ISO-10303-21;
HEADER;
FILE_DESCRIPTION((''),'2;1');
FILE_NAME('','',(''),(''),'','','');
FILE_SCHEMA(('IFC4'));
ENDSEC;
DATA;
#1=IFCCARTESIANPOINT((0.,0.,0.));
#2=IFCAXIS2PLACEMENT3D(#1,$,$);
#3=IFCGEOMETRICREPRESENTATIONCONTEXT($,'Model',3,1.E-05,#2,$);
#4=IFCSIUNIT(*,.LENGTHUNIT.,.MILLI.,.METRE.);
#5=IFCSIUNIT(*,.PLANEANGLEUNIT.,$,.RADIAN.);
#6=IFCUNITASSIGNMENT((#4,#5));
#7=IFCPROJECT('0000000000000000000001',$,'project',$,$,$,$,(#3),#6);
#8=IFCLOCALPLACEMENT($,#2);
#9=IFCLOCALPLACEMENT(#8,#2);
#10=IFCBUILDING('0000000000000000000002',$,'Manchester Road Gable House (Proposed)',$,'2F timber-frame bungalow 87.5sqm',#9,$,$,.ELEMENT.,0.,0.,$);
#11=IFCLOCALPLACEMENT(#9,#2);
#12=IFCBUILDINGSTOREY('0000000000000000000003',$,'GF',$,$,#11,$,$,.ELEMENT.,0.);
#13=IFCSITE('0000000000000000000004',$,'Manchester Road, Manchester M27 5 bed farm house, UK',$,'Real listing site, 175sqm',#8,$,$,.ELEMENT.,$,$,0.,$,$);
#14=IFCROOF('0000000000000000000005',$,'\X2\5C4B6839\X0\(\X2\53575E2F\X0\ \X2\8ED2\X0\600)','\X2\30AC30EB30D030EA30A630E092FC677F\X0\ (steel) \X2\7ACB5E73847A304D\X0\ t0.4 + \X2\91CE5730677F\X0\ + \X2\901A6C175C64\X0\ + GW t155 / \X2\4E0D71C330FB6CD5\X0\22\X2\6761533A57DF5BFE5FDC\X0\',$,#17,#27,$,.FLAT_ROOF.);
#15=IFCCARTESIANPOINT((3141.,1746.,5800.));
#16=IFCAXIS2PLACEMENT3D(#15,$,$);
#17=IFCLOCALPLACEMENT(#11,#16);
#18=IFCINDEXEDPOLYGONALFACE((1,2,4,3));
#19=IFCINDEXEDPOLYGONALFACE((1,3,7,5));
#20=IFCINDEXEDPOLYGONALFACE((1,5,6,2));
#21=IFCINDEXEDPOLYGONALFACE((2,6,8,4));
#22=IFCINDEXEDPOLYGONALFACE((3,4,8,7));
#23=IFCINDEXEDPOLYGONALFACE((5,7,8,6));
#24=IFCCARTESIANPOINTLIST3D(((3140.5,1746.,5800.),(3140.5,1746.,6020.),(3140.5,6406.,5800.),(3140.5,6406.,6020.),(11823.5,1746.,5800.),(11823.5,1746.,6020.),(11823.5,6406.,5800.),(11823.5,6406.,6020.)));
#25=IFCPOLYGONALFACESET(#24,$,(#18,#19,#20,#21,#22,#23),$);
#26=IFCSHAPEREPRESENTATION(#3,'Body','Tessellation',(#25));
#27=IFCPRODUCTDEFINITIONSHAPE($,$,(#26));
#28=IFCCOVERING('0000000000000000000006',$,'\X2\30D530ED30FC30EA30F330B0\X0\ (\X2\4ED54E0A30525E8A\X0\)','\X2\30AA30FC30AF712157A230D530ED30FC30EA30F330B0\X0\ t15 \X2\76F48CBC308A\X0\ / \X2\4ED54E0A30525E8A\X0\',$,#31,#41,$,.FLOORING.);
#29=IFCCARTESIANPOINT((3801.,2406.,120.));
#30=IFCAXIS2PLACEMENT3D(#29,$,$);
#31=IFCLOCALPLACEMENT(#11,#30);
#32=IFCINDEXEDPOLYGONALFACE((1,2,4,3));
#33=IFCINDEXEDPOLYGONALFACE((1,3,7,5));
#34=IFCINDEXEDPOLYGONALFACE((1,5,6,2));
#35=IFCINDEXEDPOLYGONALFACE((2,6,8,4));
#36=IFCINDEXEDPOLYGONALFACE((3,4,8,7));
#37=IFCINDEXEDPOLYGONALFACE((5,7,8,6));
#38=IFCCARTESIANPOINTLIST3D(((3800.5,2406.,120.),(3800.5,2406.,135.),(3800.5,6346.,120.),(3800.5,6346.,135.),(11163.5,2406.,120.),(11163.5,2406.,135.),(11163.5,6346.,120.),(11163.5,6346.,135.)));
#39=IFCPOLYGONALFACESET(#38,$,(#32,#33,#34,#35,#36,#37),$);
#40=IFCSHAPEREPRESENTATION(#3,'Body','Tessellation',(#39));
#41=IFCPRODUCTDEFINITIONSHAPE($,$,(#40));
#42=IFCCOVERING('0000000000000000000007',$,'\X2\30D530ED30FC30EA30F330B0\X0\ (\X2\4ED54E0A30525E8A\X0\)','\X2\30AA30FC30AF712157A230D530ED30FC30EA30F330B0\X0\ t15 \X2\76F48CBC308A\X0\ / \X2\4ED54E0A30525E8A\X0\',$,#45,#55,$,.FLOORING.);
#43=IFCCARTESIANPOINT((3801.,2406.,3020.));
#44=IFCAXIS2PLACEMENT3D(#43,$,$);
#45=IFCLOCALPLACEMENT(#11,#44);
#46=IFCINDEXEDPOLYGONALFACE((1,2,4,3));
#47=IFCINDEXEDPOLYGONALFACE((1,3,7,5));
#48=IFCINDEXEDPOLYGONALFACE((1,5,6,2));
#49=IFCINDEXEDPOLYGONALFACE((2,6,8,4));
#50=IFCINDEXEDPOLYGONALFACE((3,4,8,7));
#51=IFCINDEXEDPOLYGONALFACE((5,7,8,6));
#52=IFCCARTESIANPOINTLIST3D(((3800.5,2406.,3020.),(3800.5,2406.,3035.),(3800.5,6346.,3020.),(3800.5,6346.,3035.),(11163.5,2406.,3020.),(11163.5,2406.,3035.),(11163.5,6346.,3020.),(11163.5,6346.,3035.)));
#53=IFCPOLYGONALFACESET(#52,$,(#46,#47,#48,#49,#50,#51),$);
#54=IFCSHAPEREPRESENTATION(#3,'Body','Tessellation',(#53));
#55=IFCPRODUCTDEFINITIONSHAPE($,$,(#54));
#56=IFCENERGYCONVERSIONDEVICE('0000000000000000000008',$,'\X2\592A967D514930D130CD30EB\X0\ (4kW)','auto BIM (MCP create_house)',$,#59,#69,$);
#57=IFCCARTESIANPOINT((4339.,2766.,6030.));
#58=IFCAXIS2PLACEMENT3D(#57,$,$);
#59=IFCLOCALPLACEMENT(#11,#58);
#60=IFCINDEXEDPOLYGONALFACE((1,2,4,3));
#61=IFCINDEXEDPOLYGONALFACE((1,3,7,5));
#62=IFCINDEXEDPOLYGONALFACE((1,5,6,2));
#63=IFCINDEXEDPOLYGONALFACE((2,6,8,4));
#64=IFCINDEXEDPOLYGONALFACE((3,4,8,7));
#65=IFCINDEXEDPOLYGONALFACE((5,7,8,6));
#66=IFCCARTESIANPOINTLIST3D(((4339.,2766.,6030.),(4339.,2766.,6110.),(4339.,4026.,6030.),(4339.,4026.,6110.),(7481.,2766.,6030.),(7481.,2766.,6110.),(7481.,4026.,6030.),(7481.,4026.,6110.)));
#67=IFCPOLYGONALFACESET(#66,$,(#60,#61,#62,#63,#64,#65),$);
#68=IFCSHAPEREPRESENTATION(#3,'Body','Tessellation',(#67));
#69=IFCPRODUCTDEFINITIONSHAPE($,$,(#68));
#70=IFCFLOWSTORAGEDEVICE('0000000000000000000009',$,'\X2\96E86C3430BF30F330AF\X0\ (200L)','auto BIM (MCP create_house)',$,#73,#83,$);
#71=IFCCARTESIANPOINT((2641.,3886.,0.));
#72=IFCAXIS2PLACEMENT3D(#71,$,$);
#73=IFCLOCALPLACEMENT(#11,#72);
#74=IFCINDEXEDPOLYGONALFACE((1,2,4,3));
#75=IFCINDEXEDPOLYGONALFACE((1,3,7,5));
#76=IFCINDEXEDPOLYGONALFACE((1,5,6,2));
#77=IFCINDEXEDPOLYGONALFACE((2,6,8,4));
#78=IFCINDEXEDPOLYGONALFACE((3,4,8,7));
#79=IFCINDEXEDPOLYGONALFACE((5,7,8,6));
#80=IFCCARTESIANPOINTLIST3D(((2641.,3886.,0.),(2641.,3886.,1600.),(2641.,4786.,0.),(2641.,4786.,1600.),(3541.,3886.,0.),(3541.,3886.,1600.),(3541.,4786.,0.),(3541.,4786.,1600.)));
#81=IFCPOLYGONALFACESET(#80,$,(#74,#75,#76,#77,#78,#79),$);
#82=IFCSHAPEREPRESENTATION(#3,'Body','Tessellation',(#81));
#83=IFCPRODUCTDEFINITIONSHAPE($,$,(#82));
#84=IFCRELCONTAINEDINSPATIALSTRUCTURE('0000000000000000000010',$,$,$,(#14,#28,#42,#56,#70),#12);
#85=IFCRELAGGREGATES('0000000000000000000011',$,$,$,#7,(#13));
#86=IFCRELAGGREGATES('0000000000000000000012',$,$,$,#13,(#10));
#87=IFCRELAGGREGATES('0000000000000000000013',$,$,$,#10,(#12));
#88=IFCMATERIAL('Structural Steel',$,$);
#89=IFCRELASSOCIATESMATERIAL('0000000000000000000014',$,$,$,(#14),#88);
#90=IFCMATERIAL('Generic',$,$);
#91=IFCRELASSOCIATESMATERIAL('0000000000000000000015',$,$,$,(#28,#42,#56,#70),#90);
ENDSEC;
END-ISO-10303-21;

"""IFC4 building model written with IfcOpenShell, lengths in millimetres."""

from ifc_helpers import new_model, si_unit, frame, frame_2d, origin, place, context, project, spatial, rectangle, extrude, material, element, save


model = new_model("IFC4")

# Units and contexts
model_context = context("Model", 3, precision=1e-05, world=origin())
ifc_project = project(units=[si_unit("LENGTHUNIT", "METRE", prefix="MILLI"), si_unit("PLANEANGLEUNIT", "RADIAN")], contexts=[model_context])

# Site, building, storey
site_placement = place(None, origin())
site = spatial("IfcSite", under=ifc_project, at=site_placement, Name="Manchester Road, Manchester M27 5 bed farm house, UK", ObjectType="Real listing site, 175sqm", CompositionType="ELEMENT", RefElevation=0.0)
building_placement = place(site_placement, origin())
building = spatial("IfcBuilding", under=site, at=building_placement, Name="Manchester Road Gable House (Proposed)", ObjectType="2F timber-frame bungalow 87.5sqm", CompositionType="ELEMENT", ElevationOfRefHeight=0.0, ElevationOfTerrain=0.0)
storey_placement = place(building_placement, origin())
storey = spatial("IfcBuildingStorey", under=building, at=storey_placement, Name="GF", CompositionType="ELEMENT", Elevation=0.0)

# Roof
ifc_material_1 = material(Name="Structural Steel")
for number, where, name in (
    (1, (3141.0, 1746.0, 5800.0), "屋根(南帯 軒600)"),
):
    element("IfcRoof", number, at=place(storey_placement, frame(where)), inside=storey, material=ifc_material_1, Name=name, Description="ガルバリウム鋼板 (steel) 立平葺き t0.4 + 野地板 + 通気層 + GW t155 / 不燃・法22条区域対応", PredefinedType="FLAT_ROOF", context=model_context, shape_type="SweptSolid", body=[
        extrude(rectangle(XDim=8683.0, YDim=4660.0, at=frame_2d((4341.0, 2330.0))), frame((3141.0, 1746.0, 5800.0)), (0.0, 0.0, 1.0), 220.0),
    ])

# Coverings
ifc_material_2 = material(Name="Generic")
covering_1_placement = place(storey_placement, frame((3801.0, 2406.0, 120.0)))
element("IfcCovering", 2, at=covering_1_placement, inside=storey, material=ifc_material_2, Name="フローリング (仕上げ床)", Description="オーク無垢フローリング t15 直貼り / 仕上げ床", PredefinedType="FLOORING", context=model_context, shape_type="SweptSolid", body=[
    extrude(rectangle(XDim=7363.0, YDim=3940.0, at=frame_2d((3681.0, 1970.0))), frame((3801.0, 2406.0, 120.0)), (0.0, 0.0, 1.0), 15.0),
])
covering_2_placement = place(storey_placement, frame((3801.0, 2406.0, 3020.0)))
element("IfcCovering", 3, at=covering_2_placement, inside=storey, material=ifc_material_2, Name="フローリング (仕上げ床)", Description="オーク無垢フローリング t15 直貼り / 仕上げ床", PredefinedType="FLOORING", context=model_context, shape_type="SweptSolid", body=[
    extrude(rectangle(XDim=7363.0, YDim=3940.0, at=frame_2d((3681.0, 1970.0))), frame((3801.0, 2406.0, 3020.0)), (0.0, 0.0, 1.0), 15.0),
])

# Energy conversion device
energy_conversion_device_placement = place(storey_placement, frame((4339.0, 2766.0, 6030.0)))
element("IfcEnergyConversionDevice", 4, at=energy_conversion_device_placement, inside=storey, material=ifc_material_2, Name="太陽光パネル (4kW)", Description="auto BIM (MCP create_house)", context=model_context, shape_type="SweptSolid", body=[
    extrude(rectangle(XDim=3142.0, YDim=1260.0, at=frame_2d((1571.0, 630.0))), frame((4339.0, 2766.0, 6030.0)), (0.0, 0.0, 1.0), 80.0),
])

# Flow storage device
flow_storage_device_placement = place(storey_placement, frame((2641.0, 3886.0, 0.0)))
element("IfcFlowStorageDevice", 5, at=flow_storage_device_placement, inside=storey, material=ifc_material_2, Name="雨水タンク (200L)", Description="auto BIM (MCP create_house)", context=model_context, shape_type="SweptSolid", body=[
    extrude(rectangle(XDim=900.0, YDim=900.0, at=frame_2d((450.0, 450.0))), frame((2641.0, 3886.0, 0.0)), (0.0, 0.0, 1.0), 1600.0),
])

save(model, "model.ifc")
